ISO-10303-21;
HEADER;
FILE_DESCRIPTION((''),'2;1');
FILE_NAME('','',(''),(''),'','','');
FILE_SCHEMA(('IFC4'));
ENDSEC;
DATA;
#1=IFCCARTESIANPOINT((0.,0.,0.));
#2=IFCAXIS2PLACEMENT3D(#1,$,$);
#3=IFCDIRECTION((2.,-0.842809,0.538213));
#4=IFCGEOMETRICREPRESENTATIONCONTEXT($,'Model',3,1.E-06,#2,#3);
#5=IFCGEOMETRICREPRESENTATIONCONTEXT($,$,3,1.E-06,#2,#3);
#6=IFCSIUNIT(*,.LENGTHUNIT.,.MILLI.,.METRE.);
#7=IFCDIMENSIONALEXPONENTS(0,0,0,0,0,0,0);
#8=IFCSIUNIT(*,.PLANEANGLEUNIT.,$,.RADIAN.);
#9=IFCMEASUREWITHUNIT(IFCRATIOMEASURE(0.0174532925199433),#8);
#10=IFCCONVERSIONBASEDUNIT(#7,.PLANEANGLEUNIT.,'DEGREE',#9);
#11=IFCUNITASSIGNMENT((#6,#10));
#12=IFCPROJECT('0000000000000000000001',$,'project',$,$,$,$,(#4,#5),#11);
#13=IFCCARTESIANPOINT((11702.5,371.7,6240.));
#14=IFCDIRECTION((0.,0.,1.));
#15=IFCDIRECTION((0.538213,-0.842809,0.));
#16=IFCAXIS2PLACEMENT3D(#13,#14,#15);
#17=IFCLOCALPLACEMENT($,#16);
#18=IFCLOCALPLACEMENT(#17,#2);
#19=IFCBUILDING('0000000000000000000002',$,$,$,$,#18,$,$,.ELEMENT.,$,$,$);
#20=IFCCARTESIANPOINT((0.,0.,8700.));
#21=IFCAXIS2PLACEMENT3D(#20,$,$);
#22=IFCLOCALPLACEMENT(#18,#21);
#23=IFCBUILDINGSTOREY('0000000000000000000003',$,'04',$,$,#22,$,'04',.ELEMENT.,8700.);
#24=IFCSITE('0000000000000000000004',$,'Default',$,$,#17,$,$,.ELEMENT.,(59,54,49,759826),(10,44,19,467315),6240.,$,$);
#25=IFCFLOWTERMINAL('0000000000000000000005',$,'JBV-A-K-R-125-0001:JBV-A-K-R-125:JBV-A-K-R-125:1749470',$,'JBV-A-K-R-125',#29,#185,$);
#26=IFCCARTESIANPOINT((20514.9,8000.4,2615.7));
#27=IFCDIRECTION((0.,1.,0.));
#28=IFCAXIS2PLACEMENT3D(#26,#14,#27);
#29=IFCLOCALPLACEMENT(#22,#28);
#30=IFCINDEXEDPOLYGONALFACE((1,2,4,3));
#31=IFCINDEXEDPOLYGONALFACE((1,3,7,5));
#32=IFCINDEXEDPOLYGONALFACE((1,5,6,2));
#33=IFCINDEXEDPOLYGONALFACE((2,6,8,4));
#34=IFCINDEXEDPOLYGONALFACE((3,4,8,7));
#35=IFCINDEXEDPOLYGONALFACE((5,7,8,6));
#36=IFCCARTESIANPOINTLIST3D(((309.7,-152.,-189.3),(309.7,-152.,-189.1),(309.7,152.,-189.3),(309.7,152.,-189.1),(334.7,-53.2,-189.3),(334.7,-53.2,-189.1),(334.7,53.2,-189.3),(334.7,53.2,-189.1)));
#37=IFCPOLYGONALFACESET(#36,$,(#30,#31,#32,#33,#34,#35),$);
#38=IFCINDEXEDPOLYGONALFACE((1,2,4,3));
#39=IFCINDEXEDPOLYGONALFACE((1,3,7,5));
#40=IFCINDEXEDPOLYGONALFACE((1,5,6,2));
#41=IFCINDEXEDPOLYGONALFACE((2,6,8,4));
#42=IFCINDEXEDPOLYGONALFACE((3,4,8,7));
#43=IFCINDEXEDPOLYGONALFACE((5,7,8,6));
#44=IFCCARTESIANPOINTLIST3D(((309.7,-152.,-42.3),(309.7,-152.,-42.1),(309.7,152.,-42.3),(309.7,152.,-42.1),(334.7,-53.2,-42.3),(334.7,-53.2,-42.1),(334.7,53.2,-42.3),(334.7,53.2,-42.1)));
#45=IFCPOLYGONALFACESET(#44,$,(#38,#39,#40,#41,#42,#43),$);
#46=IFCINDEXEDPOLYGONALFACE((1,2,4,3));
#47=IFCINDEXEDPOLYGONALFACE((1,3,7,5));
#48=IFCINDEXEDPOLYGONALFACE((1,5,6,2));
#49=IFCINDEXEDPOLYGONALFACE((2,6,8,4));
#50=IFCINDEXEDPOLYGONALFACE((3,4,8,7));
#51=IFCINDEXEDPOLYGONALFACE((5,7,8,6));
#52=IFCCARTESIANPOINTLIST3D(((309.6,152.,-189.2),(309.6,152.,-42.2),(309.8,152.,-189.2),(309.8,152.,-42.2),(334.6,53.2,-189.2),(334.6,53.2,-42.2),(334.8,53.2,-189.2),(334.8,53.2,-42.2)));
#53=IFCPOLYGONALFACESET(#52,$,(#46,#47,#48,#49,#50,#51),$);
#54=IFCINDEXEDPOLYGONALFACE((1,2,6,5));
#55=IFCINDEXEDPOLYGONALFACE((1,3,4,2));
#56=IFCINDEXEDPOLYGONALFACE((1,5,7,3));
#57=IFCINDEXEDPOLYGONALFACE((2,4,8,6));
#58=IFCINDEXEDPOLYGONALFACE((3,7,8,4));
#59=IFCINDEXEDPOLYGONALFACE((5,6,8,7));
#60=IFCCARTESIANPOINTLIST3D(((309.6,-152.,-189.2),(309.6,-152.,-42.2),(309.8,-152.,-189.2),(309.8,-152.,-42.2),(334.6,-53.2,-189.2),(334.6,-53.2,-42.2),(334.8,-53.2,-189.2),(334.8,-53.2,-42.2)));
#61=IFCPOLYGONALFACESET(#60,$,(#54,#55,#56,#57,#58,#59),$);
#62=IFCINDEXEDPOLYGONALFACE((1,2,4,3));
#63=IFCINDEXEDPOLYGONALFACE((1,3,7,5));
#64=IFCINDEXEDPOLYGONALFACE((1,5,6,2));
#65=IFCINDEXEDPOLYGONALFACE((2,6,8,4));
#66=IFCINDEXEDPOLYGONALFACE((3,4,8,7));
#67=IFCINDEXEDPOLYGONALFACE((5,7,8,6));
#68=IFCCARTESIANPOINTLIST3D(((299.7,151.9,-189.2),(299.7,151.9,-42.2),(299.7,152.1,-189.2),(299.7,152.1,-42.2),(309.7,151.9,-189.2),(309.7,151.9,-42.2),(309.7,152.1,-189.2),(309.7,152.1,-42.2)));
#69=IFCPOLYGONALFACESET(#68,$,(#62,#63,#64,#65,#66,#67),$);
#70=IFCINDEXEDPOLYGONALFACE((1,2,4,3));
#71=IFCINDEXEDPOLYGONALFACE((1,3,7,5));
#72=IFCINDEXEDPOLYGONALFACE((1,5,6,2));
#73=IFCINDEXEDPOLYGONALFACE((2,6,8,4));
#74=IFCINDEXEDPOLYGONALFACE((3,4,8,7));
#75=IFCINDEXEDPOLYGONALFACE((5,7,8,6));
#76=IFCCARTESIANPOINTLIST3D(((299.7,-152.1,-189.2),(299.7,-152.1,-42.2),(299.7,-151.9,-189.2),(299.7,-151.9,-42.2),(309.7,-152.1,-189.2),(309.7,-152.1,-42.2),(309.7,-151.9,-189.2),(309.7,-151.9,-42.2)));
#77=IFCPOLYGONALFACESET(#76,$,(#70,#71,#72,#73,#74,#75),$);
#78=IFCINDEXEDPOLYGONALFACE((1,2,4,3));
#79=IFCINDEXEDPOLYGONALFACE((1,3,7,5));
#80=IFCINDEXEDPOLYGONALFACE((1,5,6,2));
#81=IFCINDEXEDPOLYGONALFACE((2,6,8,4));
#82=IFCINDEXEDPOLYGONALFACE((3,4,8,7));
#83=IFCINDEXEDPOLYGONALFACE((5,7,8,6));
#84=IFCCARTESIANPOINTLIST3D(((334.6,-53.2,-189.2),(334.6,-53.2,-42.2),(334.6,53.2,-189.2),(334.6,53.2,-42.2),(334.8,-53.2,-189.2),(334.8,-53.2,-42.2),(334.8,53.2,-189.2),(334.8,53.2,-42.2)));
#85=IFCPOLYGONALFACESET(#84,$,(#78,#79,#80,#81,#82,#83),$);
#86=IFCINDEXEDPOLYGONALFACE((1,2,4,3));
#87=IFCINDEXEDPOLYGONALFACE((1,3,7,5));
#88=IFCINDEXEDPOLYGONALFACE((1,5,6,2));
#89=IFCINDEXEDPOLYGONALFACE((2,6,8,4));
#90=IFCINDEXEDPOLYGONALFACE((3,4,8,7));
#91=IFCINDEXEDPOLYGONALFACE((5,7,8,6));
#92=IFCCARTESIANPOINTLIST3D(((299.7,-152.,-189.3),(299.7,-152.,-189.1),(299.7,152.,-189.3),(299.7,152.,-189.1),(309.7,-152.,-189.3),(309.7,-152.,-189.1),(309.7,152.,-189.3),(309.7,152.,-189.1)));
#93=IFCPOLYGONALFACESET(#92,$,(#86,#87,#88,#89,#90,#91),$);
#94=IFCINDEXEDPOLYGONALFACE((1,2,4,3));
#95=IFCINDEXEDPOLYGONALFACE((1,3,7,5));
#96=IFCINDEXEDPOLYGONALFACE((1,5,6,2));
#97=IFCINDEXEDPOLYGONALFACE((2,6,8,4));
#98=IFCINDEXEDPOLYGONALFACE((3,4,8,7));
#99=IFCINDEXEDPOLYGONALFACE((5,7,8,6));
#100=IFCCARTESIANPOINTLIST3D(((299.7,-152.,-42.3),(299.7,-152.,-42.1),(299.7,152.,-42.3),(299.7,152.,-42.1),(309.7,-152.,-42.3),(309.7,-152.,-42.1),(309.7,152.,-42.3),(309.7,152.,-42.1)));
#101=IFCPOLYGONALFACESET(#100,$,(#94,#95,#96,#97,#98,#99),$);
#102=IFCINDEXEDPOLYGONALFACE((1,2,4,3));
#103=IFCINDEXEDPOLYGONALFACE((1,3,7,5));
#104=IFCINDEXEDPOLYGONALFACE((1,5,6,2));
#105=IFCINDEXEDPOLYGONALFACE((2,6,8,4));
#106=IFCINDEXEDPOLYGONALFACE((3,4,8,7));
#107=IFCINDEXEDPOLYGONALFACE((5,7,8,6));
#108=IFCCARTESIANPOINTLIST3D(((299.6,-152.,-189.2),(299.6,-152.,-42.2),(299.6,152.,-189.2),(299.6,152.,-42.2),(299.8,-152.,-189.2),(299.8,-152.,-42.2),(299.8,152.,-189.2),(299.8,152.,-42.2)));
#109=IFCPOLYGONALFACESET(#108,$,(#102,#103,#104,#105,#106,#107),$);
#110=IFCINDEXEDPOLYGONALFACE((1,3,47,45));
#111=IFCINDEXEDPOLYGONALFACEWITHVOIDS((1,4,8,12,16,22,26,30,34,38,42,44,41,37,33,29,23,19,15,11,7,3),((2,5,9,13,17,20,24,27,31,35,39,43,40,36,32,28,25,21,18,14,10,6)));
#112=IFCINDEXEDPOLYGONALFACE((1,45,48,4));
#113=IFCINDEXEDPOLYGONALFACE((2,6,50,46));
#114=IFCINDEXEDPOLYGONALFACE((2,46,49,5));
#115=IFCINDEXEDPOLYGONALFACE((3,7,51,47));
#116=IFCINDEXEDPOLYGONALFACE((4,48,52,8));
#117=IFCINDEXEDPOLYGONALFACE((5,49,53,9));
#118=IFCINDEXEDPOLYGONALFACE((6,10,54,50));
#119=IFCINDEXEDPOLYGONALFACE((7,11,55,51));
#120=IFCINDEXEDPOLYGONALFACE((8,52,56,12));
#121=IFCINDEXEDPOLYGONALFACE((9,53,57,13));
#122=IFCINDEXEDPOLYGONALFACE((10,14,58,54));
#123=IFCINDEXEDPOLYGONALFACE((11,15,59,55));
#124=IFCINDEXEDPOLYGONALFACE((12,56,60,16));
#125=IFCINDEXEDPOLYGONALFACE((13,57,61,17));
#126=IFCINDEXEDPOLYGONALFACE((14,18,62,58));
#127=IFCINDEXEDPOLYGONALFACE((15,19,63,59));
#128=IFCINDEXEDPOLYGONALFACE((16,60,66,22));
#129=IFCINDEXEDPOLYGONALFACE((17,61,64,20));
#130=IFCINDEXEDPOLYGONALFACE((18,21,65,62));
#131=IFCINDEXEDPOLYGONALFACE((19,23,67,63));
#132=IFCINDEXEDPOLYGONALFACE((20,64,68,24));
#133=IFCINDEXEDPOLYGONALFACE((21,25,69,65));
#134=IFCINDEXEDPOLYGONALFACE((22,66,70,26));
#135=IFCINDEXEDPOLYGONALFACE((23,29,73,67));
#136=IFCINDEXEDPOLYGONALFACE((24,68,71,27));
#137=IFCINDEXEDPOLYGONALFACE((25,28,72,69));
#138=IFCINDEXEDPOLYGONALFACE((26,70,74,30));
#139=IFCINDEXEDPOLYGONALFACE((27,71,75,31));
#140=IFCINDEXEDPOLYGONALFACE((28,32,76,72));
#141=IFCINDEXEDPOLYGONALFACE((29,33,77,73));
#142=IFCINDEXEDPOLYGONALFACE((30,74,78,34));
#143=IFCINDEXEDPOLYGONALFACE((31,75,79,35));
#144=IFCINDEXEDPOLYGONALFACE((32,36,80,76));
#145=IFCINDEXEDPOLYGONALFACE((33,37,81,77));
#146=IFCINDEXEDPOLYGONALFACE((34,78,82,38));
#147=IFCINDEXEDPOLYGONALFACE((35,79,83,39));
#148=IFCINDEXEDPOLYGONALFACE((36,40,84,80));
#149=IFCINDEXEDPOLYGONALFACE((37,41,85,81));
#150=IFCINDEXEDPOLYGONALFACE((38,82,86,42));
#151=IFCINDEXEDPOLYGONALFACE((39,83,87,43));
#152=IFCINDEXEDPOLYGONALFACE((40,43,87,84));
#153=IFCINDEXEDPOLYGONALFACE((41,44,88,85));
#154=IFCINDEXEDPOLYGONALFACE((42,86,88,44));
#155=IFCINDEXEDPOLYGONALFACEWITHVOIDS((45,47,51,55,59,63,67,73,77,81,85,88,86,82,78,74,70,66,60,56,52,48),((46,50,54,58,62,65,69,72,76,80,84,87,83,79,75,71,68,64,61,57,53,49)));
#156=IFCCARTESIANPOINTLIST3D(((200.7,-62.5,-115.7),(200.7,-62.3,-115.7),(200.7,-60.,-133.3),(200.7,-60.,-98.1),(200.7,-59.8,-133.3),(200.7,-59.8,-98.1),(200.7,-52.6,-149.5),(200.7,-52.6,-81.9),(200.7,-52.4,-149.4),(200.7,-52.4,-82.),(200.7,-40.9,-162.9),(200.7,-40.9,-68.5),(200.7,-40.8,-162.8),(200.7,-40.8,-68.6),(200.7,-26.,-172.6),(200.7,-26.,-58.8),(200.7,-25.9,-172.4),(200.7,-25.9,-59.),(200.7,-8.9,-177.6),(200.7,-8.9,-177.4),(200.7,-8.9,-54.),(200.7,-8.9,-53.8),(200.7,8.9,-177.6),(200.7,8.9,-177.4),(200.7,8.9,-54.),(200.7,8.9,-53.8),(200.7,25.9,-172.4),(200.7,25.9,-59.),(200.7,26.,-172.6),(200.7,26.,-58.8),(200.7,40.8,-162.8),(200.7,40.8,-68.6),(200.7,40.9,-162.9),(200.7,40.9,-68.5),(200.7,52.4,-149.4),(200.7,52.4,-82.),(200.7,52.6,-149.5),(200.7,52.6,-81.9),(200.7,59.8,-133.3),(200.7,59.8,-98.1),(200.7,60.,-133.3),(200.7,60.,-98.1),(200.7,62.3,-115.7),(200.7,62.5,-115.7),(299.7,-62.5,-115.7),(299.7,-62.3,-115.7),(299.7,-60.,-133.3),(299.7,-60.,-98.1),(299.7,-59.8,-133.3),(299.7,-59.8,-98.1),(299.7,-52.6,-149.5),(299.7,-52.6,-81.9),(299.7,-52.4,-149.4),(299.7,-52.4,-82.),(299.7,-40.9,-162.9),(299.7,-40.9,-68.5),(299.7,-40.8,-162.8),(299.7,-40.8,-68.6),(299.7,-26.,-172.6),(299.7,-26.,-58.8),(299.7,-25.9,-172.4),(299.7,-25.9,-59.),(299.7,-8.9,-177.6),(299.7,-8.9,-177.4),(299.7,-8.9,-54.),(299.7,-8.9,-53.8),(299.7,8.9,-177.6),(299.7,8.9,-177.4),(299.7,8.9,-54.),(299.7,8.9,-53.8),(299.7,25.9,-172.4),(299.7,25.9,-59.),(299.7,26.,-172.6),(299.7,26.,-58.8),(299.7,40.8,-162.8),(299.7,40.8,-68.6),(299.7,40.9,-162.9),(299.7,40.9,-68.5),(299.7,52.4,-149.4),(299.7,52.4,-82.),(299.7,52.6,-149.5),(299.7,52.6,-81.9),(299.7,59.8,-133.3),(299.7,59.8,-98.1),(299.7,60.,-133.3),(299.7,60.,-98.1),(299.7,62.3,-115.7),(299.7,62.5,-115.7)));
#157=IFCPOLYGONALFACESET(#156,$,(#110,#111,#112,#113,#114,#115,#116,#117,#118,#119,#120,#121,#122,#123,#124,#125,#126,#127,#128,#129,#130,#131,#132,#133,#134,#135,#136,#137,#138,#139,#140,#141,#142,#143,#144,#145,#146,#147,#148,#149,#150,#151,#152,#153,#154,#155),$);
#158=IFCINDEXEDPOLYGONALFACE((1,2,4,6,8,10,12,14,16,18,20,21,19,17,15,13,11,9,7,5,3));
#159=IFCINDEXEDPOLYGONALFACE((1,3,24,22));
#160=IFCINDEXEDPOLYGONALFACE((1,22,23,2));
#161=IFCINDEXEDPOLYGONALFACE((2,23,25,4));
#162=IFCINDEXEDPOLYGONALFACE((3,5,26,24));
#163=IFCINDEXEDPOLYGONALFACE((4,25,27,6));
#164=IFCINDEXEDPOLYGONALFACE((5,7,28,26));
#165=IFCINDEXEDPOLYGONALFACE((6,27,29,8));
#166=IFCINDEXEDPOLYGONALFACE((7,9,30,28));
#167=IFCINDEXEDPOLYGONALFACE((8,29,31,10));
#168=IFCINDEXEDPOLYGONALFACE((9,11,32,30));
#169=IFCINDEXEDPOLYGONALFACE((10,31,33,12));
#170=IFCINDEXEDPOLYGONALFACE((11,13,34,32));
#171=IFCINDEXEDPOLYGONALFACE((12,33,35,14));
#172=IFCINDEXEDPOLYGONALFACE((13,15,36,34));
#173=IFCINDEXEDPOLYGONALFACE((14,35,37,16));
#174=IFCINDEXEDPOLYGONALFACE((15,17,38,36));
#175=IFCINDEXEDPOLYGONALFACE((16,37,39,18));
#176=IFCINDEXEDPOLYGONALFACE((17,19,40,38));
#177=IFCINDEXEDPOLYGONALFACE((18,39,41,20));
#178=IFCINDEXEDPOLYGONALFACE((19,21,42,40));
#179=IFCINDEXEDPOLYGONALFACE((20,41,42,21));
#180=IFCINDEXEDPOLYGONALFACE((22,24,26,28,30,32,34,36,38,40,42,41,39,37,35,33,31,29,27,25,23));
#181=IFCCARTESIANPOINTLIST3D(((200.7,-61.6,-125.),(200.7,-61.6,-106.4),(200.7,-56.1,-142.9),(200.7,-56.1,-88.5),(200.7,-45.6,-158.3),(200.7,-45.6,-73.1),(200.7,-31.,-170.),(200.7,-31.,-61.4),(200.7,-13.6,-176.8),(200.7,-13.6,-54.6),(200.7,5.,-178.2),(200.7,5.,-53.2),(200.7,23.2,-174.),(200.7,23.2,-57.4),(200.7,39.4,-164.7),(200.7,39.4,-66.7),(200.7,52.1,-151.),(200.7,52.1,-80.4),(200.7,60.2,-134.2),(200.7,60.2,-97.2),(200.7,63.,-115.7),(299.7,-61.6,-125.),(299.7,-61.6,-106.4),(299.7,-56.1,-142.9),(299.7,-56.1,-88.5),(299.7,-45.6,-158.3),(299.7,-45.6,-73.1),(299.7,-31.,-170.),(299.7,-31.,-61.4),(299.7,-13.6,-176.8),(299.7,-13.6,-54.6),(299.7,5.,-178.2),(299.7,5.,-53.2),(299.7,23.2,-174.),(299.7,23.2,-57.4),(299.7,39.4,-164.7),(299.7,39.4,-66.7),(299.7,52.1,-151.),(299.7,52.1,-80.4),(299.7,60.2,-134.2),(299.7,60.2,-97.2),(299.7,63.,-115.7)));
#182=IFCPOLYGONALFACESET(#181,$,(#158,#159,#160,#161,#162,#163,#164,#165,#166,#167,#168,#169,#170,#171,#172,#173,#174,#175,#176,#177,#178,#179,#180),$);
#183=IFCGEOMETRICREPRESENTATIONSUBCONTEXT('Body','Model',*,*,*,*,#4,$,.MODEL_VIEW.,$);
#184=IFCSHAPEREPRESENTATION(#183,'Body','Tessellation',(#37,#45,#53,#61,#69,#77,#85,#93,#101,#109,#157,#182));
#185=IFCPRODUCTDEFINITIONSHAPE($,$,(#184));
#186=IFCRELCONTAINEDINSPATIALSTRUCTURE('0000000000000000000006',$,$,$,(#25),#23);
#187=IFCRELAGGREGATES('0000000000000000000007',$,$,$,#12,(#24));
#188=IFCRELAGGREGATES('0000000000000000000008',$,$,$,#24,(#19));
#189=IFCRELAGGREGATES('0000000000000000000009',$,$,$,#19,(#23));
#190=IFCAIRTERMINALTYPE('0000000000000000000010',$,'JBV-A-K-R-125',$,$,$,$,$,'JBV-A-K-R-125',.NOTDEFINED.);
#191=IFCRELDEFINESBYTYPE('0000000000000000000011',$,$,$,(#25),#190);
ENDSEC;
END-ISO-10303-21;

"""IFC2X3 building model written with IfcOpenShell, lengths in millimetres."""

from ifc_helpers import new_model, entity, si_unit, converted_unit, direction, frame, frame_2d, origin, origin_2d_with_axis, place, context, subcontext, project, spatial, polyline, circle_curve, parameter, trimmed, segment, composite_curve, rectangle, circle, outline, extrude, source, transform, mapped, type_object, type_shapes, element, save


model = new_model("IFC2X3")

# Units and contexts
model_context = context("Model", 3, precision=1e-06, world=origin(), true_north=direction((2.0, -0.842809, 0.538213)))
context_of_model = context(None, 3, precision=1e-06, world=origin(), true_north=direction((2.0, -0.842809, 0.538213)))
body_context = subcontext(model_context, "Body", "Model", "MODEL_VIEW")
ifc_project = project(units=[si_unit("LENGTHUNIT", "METRE", prefix="MILLI"), converted_unit("PLANEANGLEUNIT", "DEGREE", entity("IfcRatioMeasure", 0.0174532925199433), si_unit("PLANEANGLEUNIT", "RADIAN"), dimensions=[0, 0, 0, 0, 0, 0, 0])], contexts=[model_context, context_of_model])

# Site, building, storey
site_placement = place(None, frame((11702.5, 371.7, 6240.0), z_axis=(0.0, 0.0, 1.0), x_axis=(0.538213, -0.842809, 0.0)))
site = spatial("IfcSite", under=ifc_project, at=site_placement, Name="Default", CompositionType="ELEMENT", RefLatitude=(59, 54, 49, 759826), RefLongitude=(10, 44, 19, 467315), RefElevation=6240.0)
building_placement = place(site_placement, origin())
building = spatial("IfcBuilding", under=site, at=building_placement, CompositionType="ELEMENT")
storey_placement = place(building_placement, frame((0.0, 0.0, 8700.0)))
storey = spatial("IfcBuildingStorey", under=building, at=storey_placement, Name="04", LongName="04", CompositionType="ELEMENT", Elevation=8700.0)

# Flow terminal
air_terminal_type_1 = type_object("IfcAirTerminalType", Name="JBV-A-K-R-125", ElementType="JBV-A-K-R-125", PredefinedType="NOTDEFINED")
shared_shape_1 = source(origin(), body_context, "Body", "SweptSolid", [
    extrude(outline(polyline([(-152.0, -12.5), (152.0, -12.5), (53.2, 12.5), (-53.2, 12.5), (-152.0, -12.5)])), frame((322.2, 0.0, -189.3), z_axis=(0.0, 0.0, 1.0), x_axis=(0.0, -1.0, 0.0)), (0.0, 0.0, 1.0), 0.2),
    extrude(outline(polyline([(-152.0, -12.5), (152.0, -12.5), (53.2, 12.5), (-53.2, 12.5), (-152.0, -12.5)])), frame((322.2, 0.0, -42.3), z_axis=(0.0, 0.0, 1.0), x_axis=(0.0, -1.0, 0.0)), (0.0, 0.0, 1.0), 0.2),
    extrude(rectangle(XDim=0.2, YDim=101.9, at=frame_2d((0.0, 0.0), x_axis=(1.0, 0.0))), frame((322.2, 102.6, -189.2), z_axis=(0.0, 0.0, 1.0), x_axis=(0.969446, 0.245305, 0.0)), (0.0, 0.0, 1.0), 147.0),
    extrude(rectangle(XDim=0.2, YDim=101.9, at=frame_2d((0.0, 0.0), x_axis=(1.0, 0.0))), frame((322.2, -102.6, -189.2), z_axis=(0.0, 0.0, 1.0), x_axis=(-0.969446, 0.245305, 0.0)), (0.0, 0.0, 1.0), 147.0),
    extrude(rectangle(XDim=0.2, YDim=10.0, at=frame_2d((0.0, 0.0), x_axis=(1.0, 0.0))), frame((304.7, 152.0, -189.2), z_axis=(0.0, 0.0, 1.0), x_axis=(0.0, 1.0, 0.0)), (0.0, 0.0, 1.0), 147.0),
    extrude(rectangle(XDim=0.2, YDim=10.0, at=frame_2d((0.0, 0.0), x_axis=(1.0, 0.0))), frame((304.7, -152.0, -189.2), z_axis=(0.0, 0.0, 1.0), x_axis=(0.0, 1.0, 0.0)), (0.0, 0.0, 1.0), 147.0),
    extrude(rectangle(XDim=0.2, YDim=106.4, at=frame_2d((0.0, 0.0), x_axis=(1.0, 0.0))), frame((334.7, 0.0, -189.2)), (0.0, 0.0, 1.0), 147.0),
    extrude(rectangle(XDim=304.0, YDim=10.0, at=frame_2d((0.0, 0.0), x_axis=(1.0, 0.0))), frame((304.7, 0.0, -189.3), z_axis=(0.0, 0.0, 1.0), x_axis=(0.0, -1.0, 0.0)), (0.0, 0.0, 1.0), 0.2),
    extrude(rectangle(XDim=304.0, YDim=10.0, at=frame_2d((0.0, 0.0), x_axis=(1.0, 0.0))), frame((304.7, 0.0, -42.3), z_axis=(0.0, 0.0, 1.0), x_axis=(0.0, -1.0, 0.0)), (0.0, 0.0, 1.0), 0.2),
    extrude(rectangle(XDim=0.2, YDim=304.0, at=frame_2d((0.0, 0.0), x_axis=(1.0, 0.0))), frame((299.7, 0.0, -189.2)), (0.0, 0.0, 1.0), 147.0),
    extrude(outline(composite_curve([segment(trimmed(circle_curve(origin_2d_with_axis(), 62.5), [parameter(0.0)], [parameter(180.0)], True, "PARAMETER"), True, "CONTINUOUS"), segment(trimmed(circle_curve(origin_2d_with_axis(), 62.5), [parameter(180.0)], [parameter(360.0)], True, "PARAMETER"), True, "CONTINUOUS")], self_intersect=False), holes=[composite_curve([segment(trimmed(circle_curve(origin_2d_with_axis(), 62.3), [parameter(180.0)], [parameter(360.0)], True, "PARAMETER"), False, "CONTINUOUS"), segment(trimmed(circle_curve(origin_2d_with_axis(), 62.3), [parameter(0.0)], [parameter(180.0)], True, "PARAMETER"), False, "CONTINUOUS")], self_intersect=False)]), frame((200.7, 0.0, -115.7), z_axis=(1.0, 0.0, 0.0), x_axis=(0.0, 1.0, 0.0)), (0.0, 0.0, 1.0), 99.0),
    extrude(circle(Radius=62.6, at=frame_2d((0.0, 0.0), x_axis=(1.0, 0.0))), frame((200.7, 0.3, -115.7), z_axis=(1.0, 0.0, 0.0), x_axis=(0.0, 1.0, 0.0)), (0.0, 0.0, 1.0), 99.0),
])
type_shapes(air_terminal_type_1, [shared_shape_1])
flow_terminal_1_placement = place(storey_placement, frame((20514.9, 8000.4, 2615.7), z_axis=(0.0, 0.0, 1.0), x_axis=(0.0, 1.0, 0.0)))
element("IfcFlowTerminal", 1, at=flow_terminal_1_placement, inside=storey, type_object=air_terminal_type_1, Name="JBV-A-K-R-125-0001:JBV-A-K-R-125:JBV-A-K-R-125:1749470", ObjectType="JBV-A-K-R-125", context=body_context, shape_type="MappedRepresentation", body=[
    mapped(shared_shape_1, transform((0.0, 0.0, 0.0), scale=1.0)),
])

save(model, "model.ifc")
